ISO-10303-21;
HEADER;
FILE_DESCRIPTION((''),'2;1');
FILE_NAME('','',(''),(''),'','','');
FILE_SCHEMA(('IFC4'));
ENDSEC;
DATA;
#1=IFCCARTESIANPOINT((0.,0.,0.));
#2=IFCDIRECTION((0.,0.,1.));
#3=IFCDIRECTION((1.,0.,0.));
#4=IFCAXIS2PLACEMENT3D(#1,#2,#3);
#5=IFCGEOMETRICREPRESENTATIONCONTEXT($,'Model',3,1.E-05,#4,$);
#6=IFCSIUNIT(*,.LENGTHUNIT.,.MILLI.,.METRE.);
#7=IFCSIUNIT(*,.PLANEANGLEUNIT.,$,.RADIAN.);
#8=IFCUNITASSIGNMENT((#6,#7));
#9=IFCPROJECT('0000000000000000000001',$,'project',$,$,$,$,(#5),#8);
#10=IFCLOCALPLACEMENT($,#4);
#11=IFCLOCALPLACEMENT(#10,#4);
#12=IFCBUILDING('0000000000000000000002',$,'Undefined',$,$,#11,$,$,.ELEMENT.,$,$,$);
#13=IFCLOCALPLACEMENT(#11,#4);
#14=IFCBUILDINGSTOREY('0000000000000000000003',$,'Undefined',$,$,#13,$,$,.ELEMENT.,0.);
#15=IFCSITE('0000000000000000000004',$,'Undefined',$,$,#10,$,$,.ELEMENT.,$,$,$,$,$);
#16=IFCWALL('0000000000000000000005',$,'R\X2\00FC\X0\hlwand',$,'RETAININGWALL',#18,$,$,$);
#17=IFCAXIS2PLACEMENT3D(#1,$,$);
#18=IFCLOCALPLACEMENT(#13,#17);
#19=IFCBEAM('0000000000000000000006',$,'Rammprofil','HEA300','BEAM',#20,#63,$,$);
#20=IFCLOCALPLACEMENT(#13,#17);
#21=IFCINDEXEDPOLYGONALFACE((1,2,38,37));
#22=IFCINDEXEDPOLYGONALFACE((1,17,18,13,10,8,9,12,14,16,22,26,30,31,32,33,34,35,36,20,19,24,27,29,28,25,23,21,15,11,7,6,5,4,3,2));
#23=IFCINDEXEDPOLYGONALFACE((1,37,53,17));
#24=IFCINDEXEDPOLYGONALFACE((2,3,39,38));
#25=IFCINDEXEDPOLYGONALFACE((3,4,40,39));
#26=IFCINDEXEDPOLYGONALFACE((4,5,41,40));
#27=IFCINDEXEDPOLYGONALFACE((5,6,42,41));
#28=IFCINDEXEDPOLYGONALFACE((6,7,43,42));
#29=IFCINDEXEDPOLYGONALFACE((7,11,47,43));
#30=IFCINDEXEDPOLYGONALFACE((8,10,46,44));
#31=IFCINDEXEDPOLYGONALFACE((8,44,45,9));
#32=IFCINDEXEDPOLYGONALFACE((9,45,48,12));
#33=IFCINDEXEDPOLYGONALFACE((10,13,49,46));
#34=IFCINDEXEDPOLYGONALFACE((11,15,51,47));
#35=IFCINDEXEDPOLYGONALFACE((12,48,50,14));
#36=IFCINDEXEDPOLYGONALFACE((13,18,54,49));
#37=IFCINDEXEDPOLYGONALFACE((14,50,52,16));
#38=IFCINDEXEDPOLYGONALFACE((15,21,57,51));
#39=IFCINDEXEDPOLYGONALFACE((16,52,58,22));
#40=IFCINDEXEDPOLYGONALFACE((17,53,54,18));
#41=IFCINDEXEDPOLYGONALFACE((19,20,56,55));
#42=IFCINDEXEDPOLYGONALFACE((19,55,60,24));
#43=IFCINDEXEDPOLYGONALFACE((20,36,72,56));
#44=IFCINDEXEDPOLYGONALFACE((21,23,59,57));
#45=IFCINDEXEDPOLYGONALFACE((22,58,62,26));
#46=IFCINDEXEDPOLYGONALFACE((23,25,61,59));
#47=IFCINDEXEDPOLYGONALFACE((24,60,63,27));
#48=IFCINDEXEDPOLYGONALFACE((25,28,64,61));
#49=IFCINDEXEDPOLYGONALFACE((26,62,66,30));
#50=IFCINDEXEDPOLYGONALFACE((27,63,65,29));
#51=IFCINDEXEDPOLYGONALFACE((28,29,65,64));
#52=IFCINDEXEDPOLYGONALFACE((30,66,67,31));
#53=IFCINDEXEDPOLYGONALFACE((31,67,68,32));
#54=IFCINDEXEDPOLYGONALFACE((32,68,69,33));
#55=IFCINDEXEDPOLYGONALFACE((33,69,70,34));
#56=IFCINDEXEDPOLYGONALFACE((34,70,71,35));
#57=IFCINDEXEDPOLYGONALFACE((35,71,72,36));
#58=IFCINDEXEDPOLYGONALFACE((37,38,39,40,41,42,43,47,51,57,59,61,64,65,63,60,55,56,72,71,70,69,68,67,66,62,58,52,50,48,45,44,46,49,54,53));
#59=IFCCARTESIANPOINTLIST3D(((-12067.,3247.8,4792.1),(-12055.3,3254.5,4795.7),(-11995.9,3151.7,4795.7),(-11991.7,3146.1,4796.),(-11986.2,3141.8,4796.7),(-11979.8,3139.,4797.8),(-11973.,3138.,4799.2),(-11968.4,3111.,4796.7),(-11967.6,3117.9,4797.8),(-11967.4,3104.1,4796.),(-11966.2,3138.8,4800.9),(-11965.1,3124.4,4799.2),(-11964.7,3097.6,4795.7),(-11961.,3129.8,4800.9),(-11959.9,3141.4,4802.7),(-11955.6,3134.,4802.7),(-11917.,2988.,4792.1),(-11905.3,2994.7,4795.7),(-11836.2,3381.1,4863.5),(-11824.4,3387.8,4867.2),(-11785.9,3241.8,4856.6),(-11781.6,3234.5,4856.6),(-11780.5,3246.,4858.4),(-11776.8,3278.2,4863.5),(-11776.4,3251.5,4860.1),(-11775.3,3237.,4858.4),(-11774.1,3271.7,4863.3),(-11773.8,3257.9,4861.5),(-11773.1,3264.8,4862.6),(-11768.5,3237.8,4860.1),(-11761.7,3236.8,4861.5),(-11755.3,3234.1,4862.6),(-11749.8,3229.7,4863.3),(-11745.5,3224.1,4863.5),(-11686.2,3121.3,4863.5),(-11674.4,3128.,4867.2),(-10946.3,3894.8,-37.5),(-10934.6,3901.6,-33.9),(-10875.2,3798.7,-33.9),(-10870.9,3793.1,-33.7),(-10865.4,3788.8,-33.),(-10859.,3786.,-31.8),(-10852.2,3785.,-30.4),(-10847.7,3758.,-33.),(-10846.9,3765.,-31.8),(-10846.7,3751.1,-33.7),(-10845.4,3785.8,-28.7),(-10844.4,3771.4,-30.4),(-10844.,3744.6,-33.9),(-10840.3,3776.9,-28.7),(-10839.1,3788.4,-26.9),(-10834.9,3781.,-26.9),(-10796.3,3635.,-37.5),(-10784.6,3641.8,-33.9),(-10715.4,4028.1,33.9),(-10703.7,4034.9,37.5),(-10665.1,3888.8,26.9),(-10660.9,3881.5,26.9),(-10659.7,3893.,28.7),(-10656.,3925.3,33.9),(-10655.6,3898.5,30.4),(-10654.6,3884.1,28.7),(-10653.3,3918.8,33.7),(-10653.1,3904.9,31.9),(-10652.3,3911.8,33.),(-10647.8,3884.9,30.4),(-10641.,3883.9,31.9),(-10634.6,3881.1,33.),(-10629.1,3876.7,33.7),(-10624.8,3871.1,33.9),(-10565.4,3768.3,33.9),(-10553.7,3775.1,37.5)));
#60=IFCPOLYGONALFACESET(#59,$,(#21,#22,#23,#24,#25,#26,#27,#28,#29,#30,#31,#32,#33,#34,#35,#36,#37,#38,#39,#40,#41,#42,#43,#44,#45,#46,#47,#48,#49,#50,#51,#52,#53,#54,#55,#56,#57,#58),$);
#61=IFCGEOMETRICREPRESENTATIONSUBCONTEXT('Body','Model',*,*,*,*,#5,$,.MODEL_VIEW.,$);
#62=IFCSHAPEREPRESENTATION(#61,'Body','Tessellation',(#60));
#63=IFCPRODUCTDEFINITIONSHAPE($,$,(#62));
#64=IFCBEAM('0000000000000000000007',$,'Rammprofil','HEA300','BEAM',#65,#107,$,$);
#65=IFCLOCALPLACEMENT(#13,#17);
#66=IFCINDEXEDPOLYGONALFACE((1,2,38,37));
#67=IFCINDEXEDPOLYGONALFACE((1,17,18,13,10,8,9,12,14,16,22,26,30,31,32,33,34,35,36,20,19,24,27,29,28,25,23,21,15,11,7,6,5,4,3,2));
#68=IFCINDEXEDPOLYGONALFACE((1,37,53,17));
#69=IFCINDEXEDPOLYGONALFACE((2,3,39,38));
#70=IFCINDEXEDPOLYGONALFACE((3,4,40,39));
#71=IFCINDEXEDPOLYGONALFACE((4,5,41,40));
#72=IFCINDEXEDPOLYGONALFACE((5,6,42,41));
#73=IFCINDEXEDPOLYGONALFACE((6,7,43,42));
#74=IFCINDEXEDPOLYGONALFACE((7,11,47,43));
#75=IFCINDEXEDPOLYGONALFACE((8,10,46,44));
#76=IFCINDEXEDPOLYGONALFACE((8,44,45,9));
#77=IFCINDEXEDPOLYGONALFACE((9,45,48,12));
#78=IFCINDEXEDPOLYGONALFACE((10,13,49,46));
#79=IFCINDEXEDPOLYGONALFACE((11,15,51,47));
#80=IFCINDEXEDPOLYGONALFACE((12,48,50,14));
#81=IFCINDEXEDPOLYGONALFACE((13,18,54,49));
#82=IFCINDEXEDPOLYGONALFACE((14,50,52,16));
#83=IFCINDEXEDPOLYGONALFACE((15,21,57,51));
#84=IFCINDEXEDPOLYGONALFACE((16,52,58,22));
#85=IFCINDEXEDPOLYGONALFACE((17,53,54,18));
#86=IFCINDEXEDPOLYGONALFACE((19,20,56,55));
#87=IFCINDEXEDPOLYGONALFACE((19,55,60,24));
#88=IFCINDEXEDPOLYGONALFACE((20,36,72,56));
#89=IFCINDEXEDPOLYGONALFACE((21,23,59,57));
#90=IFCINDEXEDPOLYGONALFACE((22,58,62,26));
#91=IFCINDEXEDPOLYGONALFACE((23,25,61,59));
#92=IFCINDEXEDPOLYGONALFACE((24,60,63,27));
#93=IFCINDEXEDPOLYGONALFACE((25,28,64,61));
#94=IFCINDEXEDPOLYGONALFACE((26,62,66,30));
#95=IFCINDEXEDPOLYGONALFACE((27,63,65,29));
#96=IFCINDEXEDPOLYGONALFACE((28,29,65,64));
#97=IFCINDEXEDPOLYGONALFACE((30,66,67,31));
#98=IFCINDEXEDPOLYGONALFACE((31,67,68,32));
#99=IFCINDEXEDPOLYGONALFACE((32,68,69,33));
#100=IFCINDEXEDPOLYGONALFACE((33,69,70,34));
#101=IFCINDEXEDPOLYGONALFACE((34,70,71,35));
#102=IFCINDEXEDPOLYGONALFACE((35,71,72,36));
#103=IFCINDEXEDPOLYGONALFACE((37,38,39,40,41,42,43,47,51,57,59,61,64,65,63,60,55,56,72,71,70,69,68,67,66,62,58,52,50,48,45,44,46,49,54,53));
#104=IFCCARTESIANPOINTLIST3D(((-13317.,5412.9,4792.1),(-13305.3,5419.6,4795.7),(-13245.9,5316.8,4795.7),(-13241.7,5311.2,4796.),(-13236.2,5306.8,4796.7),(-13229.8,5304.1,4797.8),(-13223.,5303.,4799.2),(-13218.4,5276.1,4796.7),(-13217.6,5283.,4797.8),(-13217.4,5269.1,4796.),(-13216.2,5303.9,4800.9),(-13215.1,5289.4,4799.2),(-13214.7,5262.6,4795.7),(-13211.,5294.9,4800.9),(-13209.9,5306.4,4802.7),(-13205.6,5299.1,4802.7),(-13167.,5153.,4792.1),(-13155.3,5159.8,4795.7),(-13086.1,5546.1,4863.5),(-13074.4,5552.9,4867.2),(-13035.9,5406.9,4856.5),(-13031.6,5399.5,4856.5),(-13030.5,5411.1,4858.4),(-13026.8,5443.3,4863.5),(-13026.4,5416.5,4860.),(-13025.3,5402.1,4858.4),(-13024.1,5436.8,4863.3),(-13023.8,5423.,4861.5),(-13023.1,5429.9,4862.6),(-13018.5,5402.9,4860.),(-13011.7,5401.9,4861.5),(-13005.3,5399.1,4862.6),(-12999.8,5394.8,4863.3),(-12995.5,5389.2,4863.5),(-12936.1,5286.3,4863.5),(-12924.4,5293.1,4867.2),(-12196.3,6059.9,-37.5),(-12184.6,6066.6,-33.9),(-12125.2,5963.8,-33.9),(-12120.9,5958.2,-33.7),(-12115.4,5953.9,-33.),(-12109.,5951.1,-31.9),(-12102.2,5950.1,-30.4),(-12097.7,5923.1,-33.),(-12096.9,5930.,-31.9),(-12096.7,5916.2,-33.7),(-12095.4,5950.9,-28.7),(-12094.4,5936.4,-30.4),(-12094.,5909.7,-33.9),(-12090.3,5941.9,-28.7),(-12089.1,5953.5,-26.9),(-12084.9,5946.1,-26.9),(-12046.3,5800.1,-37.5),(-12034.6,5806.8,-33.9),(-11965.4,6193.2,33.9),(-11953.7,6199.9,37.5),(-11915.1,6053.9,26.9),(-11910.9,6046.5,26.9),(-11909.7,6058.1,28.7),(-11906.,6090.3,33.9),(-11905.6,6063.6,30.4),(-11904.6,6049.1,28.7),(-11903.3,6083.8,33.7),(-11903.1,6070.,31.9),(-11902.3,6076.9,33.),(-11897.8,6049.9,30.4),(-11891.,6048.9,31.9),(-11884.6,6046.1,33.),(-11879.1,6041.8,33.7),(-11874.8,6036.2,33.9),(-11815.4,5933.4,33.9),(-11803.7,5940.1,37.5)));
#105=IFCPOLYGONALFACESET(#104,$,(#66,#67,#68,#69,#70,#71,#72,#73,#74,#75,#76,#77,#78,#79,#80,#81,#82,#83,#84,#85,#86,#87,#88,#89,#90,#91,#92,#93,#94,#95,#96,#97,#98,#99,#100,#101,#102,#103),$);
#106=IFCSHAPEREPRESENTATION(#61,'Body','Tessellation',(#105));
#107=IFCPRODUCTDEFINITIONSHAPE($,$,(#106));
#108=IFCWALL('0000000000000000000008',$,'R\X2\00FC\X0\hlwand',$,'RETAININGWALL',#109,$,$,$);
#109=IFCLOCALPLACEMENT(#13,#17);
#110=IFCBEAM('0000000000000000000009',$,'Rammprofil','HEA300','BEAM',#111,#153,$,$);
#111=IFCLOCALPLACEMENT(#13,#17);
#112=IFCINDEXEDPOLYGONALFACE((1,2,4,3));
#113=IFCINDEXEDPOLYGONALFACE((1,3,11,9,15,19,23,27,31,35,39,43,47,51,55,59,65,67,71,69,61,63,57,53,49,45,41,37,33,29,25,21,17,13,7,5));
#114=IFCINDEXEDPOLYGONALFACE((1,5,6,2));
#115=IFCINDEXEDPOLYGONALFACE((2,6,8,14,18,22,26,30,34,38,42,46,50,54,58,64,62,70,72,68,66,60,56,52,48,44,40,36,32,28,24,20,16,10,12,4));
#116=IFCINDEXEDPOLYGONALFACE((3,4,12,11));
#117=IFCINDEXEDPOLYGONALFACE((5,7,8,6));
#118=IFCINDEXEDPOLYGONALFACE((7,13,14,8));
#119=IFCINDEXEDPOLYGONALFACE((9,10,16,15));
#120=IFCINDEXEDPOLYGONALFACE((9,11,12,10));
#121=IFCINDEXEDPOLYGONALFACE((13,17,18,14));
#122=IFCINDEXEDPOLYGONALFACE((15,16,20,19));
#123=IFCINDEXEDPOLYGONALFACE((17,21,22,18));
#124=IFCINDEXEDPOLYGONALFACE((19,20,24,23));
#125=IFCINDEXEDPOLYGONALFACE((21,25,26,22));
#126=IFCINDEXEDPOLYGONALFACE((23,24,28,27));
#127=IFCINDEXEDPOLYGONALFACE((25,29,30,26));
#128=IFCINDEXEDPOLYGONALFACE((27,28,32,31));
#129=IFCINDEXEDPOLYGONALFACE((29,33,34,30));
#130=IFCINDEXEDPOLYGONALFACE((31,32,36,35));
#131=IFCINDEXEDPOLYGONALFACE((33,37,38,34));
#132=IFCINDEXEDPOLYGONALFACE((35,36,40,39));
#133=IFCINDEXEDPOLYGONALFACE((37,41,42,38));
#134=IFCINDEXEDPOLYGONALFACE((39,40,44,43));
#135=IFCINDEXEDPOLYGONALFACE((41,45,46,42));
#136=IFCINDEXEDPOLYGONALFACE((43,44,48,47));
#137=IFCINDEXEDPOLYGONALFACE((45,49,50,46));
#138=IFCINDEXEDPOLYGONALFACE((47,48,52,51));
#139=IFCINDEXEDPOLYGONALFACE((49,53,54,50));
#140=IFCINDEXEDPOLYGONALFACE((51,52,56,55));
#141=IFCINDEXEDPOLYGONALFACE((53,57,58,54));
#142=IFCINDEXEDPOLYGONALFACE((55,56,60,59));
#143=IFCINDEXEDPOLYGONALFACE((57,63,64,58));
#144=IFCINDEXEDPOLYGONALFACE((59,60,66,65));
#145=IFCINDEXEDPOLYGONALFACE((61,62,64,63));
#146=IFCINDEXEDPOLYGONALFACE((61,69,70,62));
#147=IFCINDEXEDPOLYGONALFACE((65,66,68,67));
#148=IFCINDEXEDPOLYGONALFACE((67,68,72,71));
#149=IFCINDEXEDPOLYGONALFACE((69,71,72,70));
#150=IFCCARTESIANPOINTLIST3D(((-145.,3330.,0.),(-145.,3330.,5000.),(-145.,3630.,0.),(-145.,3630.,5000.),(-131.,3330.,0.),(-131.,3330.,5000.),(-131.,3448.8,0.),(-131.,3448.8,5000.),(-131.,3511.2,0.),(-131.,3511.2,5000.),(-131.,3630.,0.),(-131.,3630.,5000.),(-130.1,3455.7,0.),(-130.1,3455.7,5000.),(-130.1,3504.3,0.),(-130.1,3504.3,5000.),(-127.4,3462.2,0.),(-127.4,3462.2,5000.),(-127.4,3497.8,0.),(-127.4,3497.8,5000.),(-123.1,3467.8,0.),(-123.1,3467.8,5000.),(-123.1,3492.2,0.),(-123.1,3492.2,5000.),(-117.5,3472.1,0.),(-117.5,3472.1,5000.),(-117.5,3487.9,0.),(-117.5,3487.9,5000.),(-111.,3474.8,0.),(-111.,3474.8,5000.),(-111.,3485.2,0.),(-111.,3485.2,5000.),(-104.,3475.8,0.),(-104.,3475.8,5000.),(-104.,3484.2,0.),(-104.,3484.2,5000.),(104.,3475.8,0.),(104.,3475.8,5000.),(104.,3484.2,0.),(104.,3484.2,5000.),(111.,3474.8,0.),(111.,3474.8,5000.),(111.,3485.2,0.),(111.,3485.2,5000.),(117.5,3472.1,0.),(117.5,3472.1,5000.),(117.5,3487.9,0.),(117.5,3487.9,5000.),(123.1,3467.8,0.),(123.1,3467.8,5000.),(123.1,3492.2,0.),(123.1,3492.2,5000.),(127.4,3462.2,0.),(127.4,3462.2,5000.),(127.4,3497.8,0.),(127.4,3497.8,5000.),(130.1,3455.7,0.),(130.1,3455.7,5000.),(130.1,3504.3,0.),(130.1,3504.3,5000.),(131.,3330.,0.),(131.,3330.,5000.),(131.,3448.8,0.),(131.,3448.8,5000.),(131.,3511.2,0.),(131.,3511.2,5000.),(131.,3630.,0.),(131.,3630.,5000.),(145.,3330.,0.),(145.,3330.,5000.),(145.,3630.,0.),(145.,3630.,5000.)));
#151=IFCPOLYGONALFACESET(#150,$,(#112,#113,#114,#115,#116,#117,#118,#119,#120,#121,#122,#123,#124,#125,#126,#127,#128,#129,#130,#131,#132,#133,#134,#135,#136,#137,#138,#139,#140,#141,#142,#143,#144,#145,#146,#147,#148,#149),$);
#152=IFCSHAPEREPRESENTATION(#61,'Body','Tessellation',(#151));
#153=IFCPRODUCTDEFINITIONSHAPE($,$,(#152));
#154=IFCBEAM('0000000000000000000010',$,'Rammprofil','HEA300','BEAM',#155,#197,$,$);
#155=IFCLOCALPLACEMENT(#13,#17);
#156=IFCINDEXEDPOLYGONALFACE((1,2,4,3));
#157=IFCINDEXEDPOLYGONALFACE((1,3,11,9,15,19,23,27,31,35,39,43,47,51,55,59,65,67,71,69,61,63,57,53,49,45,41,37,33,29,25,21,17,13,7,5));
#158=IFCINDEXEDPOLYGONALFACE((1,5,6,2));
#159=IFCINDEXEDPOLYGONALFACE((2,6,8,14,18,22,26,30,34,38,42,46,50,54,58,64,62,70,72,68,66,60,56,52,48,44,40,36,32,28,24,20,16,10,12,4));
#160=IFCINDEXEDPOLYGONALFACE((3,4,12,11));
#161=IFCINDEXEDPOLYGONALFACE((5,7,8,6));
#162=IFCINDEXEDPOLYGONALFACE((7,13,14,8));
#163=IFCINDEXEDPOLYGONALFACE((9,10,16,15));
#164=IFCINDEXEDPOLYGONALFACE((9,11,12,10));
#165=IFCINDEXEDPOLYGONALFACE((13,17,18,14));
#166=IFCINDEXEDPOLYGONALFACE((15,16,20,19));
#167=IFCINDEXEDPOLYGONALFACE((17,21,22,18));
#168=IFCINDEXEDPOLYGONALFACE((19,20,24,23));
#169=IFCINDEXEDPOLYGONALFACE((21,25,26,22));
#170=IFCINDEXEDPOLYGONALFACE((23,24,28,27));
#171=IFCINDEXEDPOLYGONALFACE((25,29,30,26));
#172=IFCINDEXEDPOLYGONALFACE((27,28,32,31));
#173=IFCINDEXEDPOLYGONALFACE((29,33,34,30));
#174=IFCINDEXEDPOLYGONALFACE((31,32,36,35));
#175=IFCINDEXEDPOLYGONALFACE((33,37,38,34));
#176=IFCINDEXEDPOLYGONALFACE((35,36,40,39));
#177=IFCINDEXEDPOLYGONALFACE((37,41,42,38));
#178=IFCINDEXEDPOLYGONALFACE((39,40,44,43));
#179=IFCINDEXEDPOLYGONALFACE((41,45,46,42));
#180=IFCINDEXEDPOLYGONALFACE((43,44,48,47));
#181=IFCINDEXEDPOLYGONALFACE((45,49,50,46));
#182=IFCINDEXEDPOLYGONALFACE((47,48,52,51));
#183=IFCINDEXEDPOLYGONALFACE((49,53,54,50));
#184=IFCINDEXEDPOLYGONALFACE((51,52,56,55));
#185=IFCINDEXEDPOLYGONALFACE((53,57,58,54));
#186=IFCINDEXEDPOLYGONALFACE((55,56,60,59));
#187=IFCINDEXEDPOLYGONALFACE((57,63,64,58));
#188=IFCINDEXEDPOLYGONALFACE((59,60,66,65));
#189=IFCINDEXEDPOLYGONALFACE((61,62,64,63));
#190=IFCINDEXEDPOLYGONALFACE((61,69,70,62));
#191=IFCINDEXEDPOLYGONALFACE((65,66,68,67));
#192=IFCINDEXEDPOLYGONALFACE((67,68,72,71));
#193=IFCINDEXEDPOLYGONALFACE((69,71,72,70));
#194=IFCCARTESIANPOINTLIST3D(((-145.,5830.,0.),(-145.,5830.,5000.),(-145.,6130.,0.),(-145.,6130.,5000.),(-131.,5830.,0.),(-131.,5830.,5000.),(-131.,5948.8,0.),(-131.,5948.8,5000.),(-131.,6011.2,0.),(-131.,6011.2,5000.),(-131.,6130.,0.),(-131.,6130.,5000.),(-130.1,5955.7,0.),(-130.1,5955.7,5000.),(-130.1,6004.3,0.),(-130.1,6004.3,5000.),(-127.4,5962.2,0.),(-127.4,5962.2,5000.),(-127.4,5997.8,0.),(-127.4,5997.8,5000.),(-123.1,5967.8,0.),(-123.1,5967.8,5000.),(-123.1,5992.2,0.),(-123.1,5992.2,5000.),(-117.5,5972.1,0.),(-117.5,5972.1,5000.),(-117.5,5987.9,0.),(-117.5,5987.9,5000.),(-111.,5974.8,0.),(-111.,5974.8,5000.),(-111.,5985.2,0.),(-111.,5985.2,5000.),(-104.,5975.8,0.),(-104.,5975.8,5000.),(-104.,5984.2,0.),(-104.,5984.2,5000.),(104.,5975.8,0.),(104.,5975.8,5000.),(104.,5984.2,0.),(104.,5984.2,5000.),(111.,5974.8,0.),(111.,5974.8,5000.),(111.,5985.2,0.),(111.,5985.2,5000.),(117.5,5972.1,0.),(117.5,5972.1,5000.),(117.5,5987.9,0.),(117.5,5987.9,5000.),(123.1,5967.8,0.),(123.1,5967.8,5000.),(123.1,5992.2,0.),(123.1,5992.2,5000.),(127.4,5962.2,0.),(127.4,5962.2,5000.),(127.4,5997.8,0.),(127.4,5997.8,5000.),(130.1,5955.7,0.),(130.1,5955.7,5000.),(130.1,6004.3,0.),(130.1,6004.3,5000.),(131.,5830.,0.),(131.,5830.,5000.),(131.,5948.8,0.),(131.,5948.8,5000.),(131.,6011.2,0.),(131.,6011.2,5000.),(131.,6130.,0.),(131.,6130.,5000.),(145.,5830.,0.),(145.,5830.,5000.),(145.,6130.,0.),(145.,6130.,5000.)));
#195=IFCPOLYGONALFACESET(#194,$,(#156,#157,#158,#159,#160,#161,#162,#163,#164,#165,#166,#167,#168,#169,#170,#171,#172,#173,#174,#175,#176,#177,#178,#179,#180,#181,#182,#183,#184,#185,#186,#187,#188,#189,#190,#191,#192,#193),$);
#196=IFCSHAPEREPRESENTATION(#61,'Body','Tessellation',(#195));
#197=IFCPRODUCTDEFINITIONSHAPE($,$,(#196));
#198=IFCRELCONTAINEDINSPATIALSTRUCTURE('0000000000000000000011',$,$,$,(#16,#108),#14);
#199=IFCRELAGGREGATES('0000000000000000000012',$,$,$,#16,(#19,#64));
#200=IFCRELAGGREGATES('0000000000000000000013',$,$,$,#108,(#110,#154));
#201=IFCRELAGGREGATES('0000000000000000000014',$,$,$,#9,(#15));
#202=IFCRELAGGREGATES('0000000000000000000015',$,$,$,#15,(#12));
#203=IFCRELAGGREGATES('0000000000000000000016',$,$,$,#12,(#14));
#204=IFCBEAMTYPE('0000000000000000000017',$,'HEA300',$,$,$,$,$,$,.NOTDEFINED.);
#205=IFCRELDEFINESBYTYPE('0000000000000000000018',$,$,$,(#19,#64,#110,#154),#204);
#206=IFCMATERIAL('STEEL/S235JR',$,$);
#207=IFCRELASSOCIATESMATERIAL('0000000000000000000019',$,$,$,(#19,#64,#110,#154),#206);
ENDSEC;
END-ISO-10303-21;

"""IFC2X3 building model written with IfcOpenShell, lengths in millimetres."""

from ifc_helpers import new_model, si_unit, frame, origin_with_axes, origin_2d_with_axis, place, context, subcontext, project, spatial, i_section, extrude, material, type_object, element, aggregate, save


model = new_model("IFC2X3")

# Units and contexts
model_context = context("Model", 3, precision=1e-05, world=origin_with_axes())
body_context = subcontext(model_context, "Body", "Model", "MODEL_VIEW")
ifc_project = project(units=[si_unit("LENGTHUNIT", "METRE", prefix="MILLI"), si_unit("PLANEANGLEUNIT", "RADIAN")], contexts=[model_context])

# Site, building, storey
site_placement = place(None, origin_with_axes())
site = spatial("IfcSite", under=ifc_project, at=site_placement, Name="Undefined", CompositionType="ELEMENT")
building_placement = place(site_placement, origin_with_axes())
building = spatial("IfcBuilding", under=site, at=building_placement, Name="Undefined", CompositionType="ELEMENT")
storey_placement = place(building_placement, origin_with_axes())
storey = spatial("IfcBuildingStorey", under=building, at=storey_placement, Name="Undefined", CompositionType="ELEMENT", Elevation=0.0)

# Walls, beams
wall_1_placement = place(storey_placement, origin_with_axes())
wall_1 = element("IfcWall", 1, at=wall_1_placement, inside=storey, Name="Rühlwand", ObjectType="RETAININGWALL")
ifc_material_1 = material(Name="STEEL/S235JR")
beam_type_1 = type_object("IfcBeamType", Name="HEA300", PredefinedType="NOTDEFINED")
beam_1_placement = place(wall_1_placement, frame((-10750.0, 3834.9, 0.0), z_axis=(-0.836516, -0.482964, -0.258819), x_axis=(-0.224147, -0.129405, 0.965926)))
beam_1 = element("IfcBeam", 2, at=beam_1_placement, type_object=beam_type_1, material=ifc_material_1, Name="Rammprofil", Description="HEA300", ObjectType="BEAM", context=body_context, shape_type="SweptSolid", body=[
    extrude(i_section(OverallWidth=300.0, OverallDepth=290.0, WebThickness=8.5, FlangeThickness=14.0, FilletRadius=27.0, at=origin_2d_with_axis()), frame((5000.0, 0.0, 0.0), z_axis=(-1.0, 0.0, 0.0), x_axis=(0.0, -1.0, 0.0)), (0.0, 0.0, 1.0), 5000.0),
])
beam_2_placement = place(wall_1_placement, frame((-12000.0, 6000.0, 0.0), z_axis=(-0.836516, -0.482964, -0.258819), x_axis=(-0.224147, -0.129405, 0.965926)))
beam_2 = element("IfcBeam", 3, at=beam_2_placement, type_object=beam_type_1, material=ifc_material_1, Name="Rammprofil", Description="HEA300", ObjectType="BEAM", context=body_context, shape_type="SweptSolid", body=[
    extrude(i_section(OverallWidth=300.0, OverallDepth=290.0, WebThickness=8.5, FlangeThickness=14.0, FilletRadius=27.0, at=origin_2d_with_axis()), frame((5000.0, 0.0, 0.0), z_axis=(-1.0, 0.0, 0.0), x_axis=(0.0, -1.0, 0.0)), (0.0, 0.0, 1.0), 5000.0),
])
wall_2_placement = place(storey_placement, origin_with_axes())
wall_2 = element("IfcWall", 4, at=wall_2_placement, inside=storey, Name="Rühlwand", ObjectType="RETAININGWALL")
beam_3_placement = place(wall_2_placement, frame((0.0, 3480.0, 0.0), z_axis=(-1.0, 0.0, 0.0), x_axis=(0.0, 0.0, 1.0)))
beam_3 = element("IfcBeam", 5, at=beam_3_placement, type_object=beam_type_1, material=ifc_material_1, Name="Rammprofil", Description="HEA300", ObjectType="BEAM", context=body_context, shape_type="SweptSolid", body=[
    extrude(i_section(OverallWidth=300.0, OverallDepth=290.0, WebThickness=8.5, FlangeThickness=14.0, FilletRadius=27.0, at=origin_2d_with_axis()), frame((5000.0, 0.0, 0.0), z_axis=(-1.0, 0.0, 0.0), x_axis=(0.0, -1.0, 0.0)), (0.0, 0.0, 1.0), 5000.0),
])
beam_4_placement = place(wall_2_placement, frame((0.0, 5980.0, 0.0), z_axis=(-1.0, 0.0, 0.0), x_axis=(0.0, 0.0, 1.0)))
beam_4 = element("IfcBeam", 6, at=beam_4_placement, type_object=beam_type_1, material=ifc_material_1, Name="Rammprofil", Description="HEA300", ObjectType="BEAM", context=body_context, shape_type="SweptSolid", body=[
    extrude(i_section(OverallWidth=300.0, OverallDepth=290.0, WebThickness=8.5, FlangeThickness=14.0, FilletRadius=27.0, at=origin_2d_with_axis()), frame((5000.0, 0.0, 0.0), z_axis=(-1.0, 0.0, 0.0), x_axis=(0.0, -1.0, 0.0)), (0.0, 0.0, 1.0), 5000.0),
])

aggregate(wall_1, [beam_1, beam_2])
aggregate(wall_2, [beam_3, beam_4])

save(model, "model.ifc")
